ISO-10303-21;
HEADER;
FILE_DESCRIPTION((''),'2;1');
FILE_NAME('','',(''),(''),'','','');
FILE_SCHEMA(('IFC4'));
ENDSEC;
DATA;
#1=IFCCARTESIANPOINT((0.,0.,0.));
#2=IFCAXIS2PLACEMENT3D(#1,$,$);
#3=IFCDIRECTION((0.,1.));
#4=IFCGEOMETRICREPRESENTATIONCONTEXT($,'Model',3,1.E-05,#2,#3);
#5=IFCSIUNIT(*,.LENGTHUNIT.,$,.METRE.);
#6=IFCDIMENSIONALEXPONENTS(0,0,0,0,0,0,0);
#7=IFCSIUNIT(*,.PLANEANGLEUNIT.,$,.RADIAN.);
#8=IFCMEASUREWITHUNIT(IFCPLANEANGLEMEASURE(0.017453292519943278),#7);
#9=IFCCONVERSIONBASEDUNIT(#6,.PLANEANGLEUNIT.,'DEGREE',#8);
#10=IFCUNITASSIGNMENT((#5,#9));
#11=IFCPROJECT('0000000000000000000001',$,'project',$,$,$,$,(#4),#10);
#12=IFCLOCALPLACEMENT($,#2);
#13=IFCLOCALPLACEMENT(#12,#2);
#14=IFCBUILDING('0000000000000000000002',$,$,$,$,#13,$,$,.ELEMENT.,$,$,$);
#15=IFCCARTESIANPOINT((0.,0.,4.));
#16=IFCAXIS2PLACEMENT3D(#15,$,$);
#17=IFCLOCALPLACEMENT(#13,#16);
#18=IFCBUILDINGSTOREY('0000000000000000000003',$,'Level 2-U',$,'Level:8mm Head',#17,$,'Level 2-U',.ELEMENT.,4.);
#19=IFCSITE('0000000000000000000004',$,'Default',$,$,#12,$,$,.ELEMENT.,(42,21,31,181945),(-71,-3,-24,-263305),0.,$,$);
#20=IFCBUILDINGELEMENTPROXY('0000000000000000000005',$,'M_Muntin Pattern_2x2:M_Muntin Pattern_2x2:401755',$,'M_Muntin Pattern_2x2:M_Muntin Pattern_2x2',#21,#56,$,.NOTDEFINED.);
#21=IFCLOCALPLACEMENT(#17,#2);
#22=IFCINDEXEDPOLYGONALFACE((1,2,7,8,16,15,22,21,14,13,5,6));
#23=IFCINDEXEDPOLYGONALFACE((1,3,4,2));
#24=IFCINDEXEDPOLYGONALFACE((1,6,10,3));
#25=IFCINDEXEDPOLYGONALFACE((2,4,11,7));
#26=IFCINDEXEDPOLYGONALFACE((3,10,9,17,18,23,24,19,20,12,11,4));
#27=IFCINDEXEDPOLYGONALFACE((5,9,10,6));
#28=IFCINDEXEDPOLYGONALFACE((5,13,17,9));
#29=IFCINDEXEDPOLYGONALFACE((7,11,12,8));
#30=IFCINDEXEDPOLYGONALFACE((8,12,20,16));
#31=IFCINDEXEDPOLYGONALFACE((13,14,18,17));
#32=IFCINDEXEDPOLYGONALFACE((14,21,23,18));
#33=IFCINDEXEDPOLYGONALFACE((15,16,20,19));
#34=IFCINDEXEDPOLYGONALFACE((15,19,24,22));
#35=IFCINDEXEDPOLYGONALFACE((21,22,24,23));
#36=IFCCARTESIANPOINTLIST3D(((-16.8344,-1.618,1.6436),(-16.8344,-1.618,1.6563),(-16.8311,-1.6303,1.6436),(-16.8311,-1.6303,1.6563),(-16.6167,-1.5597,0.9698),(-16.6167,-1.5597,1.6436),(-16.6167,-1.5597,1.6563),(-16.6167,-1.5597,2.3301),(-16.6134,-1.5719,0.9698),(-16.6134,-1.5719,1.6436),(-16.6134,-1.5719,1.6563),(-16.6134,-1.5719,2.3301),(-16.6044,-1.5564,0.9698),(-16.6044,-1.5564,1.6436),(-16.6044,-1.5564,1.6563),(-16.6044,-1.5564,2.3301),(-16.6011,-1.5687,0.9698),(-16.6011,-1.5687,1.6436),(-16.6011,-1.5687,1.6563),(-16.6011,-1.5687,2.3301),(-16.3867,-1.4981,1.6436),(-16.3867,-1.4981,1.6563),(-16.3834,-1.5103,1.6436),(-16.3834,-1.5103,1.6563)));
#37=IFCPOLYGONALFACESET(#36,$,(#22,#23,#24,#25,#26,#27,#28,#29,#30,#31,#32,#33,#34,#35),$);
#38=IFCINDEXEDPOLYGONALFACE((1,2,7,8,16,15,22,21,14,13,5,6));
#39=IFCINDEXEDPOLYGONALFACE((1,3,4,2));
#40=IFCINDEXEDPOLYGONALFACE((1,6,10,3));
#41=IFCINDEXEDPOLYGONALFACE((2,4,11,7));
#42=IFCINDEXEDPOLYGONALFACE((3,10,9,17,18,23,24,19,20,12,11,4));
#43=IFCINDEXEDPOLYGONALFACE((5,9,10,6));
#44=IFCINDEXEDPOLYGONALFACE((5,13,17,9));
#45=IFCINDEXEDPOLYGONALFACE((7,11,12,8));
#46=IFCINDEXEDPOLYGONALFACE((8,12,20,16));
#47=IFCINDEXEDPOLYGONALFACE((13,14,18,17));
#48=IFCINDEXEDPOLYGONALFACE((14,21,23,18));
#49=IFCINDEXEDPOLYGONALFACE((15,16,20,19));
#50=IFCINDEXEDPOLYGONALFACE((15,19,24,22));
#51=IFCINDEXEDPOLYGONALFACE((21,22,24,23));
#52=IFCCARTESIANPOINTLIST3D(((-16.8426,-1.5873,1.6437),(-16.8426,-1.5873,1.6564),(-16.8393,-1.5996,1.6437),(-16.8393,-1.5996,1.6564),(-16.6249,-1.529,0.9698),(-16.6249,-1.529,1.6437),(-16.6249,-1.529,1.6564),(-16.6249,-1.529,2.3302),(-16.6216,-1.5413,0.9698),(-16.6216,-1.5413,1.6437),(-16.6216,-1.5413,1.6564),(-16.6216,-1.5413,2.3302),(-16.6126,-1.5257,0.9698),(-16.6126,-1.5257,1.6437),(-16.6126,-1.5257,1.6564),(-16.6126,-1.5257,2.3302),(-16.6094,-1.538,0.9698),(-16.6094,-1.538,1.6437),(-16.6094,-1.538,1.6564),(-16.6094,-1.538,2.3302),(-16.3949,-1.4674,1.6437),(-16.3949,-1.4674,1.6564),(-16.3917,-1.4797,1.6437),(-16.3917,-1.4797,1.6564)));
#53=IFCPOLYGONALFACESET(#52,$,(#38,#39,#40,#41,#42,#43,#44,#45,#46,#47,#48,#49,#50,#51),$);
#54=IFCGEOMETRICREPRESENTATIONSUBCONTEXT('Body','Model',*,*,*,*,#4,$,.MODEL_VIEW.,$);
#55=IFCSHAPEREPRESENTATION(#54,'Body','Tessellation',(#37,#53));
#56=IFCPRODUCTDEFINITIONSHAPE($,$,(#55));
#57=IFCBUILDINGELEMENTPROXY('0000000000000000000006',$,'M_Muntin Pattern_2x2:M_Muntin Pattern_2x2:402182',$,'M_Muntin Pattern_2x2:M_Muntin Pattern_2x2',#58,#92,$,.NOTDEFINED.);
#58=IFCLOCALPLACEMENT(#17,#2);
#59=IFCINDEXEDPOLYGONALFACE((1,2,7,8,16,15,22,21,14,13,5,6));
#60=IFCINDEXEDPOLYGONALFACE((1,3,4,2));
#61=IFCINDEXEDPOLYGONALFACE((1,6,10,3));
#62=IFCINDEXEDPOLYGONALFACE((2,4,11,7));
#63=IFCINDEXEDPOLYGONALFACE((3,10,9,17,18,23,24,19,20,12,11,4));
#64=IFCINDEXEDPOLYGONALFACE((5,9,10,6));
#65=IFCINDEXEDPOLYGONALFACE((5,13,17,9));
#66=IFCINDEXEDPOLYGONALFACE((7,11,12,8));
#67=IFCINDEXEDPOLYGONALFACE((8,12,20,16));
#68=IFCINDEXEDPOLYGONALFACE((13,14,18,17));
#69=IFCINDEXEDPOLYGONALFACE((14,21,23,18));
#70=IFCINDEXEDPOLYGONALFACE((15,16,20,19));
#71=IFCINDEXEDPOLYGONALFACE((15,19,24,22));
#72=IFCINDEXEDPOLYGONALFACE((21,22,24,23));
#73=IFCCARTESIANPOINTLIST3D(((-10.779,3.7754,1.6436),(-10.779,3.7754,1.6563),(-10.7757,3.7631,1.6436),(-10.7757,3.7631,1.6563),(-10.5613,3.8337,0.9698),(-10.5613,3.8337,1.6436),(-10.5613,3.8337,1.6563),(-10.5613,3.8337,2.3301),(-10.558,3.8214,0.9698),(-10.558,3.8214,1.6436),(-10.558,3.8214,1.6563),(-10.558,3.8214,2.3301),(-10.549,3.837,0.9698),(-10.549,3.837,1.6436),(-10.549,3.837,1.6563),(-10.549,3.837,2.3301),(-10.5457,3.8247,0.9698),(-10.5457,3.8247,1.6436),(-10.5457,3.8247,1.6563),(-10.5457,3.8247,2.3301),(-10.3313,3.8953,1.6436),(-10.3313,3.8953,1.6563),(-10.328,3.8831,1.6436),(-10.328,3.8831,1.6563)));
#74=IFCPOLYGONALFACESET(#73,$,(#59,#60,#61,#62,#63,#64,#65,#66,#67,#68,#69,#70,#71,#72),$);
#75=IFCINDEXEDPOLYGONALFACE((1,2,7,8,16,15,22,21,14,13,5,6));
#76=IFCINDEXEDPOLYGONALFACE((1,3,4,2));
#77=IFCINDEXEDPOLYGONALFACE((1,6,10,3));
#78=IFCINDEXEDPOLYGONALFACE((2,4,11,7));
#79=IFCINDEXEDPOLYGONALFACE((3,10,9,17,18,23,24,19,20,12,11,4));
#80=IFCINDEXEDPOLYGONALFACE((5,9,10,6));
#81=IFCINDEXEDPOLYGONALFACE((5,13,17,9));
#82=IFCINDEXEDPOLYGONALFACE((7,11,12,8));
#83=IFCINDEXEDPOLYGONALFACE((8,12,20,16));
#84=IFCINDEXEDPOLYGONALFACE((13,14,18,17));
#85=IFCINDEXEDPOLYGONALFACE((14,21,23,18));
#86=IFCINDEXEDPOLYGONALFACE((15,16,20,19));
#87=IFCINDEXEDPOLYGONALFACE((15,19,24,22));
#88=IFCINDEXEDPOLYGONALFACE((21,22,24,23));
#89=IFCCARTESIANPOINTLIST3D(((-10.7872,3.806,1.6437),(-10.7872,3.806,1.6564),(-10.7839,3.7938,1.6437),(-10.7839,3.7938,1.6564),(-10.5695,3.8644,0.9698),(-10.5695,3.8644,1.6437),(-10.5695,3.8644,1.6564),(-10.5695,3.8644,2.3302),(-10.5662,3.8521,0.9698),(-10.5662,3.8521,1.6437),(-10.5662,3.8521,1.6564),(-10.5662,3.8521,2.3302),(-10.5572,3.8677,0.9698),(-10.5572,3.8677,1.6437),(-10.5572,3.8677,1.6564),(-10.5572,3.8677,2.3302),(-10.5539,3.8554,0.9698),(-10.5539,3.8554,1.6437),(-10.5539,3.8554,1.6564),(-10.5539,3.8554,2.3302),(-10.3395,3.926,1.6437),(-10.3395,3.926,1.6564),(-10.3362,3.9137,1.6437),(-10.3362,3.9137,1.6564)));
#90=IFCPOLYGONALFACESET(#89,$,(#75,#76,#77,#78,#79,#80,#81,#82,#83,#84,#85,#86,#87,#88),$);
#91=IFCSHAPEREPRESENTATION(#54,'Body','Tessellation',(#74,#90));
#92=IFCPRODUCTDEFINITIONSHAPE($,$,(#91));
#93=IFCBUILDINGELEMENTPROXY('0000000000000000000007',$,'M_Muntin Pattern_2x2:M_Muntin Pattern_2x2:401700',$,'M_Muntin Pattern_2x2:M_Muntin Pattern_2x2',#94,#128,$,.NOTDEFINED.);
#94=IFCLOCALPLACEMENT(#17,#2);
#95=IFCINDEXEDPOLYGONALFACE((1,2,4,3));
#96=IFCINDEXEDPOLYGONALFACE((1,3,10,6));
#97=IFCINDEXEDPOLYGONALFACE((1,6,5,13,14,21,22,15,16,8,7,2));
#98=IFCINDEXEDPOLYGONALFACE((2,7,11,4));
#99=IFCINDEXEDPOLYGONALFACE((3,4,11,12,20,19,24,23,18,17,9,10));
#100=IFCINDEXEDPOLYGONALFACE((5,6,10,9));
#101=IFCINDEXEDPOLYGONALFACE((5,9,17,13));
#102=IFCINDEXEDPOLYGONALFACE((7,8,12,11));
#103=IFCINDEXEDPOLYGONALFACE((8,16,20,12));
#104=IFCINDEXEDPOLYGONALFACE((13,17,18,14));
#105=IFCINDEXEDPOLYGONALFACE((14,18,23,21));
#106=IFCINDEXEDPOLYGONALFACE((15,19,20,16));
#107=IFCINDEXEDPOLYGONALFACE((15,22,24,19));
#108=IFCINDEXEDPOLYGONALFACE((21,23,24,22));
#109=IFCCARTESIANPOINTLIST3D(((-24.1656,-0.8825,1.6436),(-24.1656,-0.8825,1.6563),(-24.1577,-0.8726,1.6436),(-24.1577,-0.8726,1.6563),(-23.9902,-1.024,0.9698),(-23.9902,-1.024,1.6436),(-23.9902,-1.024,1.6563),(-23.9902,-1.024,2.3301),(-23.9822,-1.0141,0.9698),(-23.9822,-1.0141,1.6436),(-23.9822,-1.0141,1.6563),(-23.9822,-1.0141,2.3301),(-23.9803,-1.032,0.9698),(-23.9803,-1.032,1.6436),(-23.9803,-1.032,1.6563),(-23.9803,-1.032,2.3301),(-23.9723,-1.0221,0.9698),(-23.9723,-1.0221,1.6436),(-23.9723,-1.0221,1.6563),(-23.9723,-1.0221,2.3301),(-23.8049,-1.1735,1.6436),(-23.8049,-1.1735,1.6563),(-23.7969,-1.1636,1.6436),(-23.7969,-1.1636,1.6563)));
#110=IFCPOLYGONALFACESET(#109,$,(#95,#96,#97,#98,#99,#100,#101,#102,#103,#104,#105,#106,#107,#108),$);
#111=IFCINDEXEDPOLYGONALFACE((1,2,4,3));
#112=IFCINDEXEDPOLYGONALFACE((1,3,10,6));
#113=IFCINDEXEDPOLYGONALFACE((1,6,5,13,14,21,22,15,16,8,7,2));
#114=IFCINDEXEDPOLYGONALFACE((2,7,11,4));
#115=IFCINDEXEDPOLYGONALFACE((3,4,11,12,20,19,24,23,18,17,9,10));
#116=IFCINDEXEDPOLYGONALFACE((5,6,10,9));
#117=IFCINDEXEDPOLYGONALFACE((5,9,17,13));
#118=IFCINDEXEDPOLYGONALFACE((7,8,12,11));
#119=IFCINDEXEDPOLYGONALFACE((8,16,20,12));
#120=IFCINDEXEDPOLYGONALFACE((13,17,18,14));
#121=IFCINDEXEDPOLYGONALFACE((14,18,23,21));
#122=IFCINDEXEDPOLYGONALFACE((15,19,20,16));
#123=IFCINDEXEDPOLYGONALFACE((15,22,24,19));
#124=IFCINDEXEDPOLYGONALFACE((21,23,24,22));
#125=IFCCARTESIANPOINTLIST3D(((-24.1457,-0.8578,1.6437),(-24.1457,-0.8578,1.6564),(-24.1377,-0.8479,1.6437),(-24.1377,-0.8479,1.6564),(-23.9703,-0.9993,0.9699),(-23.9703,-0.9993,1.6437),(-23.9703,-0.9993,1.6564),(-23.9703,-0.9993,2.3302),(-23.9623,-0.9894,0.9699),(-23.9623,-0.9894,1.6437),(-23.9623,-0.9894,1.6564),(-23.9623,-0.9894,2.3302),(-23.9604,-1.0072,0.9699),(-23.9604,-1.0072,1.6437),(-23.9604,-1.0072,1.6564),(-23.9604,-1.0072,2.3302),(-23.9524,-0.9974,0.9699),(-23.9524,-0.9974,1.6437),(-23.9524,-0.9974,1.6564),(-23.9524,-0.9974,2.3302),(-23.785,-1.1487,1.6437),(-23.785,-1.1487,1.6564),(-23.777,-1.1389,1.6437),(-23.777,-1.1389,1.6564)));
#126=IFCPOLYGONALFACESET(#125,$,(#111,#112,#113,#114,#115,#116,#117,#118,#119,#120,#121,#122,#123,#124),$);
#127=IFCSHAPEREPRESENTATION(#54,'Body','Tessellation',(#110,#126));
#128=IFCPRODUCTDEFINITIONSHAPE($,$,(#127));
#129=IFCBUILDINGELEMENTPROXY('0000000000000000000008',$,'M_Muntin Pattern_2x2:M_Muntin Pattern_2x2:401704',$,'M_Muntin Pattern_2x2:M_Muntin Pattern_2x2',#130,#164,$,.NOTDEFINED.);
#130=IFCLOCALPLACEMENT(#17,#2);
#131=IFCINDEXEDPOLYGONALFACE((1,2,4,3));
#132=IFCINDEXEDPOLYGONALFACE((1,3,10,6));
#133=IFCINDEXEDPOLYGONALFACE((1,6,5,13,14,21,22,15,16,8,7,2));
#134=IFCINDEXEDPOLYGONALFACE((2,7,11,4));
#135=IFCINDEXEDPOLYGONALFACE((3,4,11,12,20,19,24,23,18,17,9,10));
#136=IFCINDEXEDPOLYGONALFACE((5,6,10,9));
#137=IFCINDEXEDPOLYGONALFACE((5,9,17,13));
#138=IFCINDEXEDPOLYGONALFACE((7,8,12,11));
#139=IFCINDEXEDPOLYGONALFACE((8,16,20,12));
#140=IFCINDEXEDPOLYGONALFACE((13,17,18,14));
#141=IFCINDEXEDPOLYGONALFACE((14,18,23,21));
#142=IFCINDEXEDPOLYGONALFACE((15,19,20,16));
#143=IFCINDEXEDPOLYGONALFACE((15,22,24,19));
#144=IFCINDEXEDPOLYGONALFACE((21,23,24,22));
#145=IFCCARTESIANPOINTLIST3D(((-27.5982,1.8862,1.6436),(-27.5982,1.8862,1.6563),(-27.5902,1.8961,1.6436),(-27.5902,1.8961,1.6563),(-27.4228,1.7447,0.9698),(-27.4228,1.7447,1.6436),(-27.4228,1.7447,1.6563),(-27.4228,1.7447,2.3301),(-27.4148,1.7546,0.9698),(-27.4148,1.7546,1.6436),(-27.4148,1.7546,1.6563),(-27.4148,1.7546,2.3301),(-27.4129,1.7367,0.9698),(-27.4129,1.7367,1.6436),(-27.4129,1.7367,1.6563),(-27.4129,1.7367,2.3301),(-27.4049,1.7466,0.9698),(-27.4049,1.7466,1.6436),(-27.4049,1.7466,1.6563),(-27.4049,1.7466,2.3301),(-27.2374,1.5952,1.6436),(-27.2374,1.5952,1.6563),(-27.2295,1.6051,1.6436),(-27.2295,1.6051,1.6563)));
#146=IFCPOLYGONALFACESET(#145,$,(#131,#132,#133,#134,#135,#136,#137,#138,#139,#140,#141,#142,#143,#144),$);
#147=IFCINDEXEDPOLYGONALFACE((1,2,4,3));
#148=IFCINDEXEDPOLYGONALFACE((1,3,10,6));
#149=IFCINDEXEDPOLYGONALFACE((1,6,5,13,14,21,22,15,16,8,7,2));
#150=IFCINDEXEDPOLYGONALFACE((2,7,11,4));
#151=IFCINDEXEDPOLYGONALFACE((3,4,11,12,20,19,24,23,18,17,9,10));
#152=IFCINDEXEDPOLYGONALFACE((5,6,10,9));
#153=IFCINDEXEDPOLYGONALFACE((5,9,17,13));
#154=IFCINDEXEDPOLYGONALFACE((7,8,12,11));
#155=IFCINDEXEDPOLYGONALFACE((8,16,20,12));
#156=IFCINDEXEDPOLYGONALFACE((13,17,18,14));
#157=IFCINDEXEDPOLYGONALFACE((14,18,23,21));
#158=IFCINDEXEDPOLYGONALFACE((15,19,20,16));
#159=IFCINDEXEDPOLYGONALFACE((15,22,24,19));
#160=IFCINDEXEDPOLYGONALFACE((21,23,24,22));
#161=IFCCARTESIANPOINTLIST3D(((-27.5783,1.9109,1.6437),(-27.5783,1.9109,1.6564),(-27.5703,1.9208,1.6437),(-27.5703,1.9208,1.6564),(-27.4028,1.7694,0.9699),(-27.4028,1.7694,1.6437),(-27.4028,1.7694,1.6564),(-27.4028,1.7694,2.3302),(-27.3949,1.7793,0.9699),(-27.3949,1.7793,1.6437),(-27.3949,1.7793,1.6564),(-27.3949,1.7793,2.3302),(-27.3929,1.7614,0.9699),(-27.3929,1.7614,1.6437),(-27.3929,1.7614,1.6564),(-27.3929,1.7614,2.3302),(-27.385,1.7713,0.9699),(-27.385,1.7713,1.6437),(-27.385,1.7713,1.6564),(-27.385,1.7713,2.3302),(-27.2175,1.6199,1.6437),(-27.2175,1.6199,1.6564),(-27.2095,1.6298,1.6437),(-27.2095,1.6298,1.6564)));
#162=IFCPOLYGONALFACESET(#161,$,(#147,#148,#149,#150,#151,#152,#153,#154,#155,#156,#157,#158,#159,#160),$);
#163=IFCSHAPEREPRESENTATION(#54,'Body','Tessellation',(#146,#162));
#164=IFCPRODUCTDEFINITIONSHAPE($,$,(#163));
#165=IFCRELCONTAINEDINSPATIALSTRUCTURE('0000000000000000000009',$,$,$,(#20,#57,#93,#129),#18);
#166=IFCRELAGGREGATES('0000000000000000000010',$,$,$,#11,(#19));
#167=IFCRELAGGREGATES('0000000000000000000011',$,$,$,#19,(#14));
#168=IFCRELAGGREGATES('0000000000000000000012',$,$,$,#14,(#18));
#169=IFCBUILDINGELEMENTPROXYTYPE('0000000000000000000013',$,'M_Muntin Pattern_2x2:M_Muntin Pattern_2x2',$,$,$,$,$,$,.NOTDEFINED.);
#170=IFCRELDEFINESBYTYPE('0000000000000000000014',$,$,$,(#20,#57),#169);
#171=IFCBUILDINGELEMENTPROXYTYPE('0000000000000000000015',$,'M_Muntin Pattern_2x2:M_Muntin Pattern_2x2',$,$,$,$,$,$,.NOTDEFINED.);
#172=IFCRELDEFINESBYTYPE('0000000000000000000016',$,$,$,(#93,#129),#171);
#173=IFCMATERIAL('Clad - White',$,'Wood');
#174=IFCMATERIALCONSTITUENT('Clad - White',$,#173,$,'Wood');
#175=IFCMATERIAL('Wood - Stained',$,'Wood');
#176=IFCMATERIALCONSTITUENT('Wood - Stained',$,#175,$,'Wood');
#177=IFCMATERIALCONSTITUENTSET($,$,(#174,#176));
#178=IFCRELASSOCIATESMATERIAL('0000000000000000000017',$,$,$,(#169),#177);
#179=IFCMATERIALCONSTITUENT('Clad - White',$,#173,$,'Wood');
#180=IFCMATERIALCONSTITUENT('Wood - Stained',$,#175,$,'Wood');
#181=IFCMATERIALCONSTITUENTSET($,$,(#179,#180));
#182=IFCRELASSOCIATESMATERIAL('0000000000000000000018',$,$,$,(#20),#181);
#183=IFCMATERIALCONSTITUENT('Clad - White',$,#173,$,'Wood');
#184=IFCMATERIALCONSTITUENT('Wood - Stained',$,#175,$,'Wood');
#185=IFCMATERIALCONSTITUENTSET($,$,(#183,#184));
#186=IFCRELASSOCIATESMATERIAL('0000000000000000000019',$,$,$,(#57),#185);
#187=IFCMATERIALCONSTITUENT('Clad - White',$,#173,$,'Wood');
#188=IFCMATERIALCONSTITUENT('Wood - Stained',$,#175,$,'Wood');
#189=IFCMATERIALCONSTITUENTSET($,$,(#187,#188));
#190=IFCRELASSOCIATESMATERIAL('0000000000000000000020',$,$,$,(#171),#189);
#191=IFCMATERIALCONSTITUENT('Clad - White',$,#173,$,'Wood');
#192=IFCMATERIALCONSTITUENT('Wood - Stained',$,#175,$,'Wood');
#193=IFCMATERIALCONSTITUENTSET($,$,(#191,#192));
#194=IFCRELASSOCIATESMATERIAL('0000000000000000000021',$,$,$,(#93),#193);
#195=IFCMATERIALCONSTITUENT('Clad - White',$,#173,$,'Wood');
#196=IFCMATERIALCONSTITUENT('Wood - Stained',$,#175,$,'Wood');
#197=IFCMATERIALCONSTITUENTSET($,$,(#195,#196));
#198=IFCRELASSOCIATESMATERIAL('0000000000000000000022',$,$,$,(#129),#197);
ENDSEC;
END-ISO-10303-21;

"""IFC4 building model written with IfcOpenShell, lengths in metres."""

from ifc_helpers import new_model, entity, si_unit, converted_unit, direction, frame, origin, place, context, subcontext, project, spatial, polyline, outline, extrude, source, transform, mapped, material, constituent, constituent_set, type_object, type_shapes, element, save


model = new_model("IFC4")

# Units and contexts
model_context = context("Model", 3, precision=1e-05, world=origin(), true_north=direction((0.0, 1.0)))
body_context = subcontext(model_context, "Body", "Model", "MODEL_VIEW")
ifc_project = project(units=[si_unit("LENGTHUNIT", "METRE"), converted_unit("PLANEANGLEUNIT", "DEGREE", entity("IfcPlaneAngleMeasure", 0.017453292519943278), si_unit("PLANEANGLEUNIT", "RADIAN"), dimensions=[0, 0, 0, 0, 0, 0, 0])], contexts=[model_context])

# Site, building, storey
site_placement = place(None, origin())
site = spatial("IfcSite", under=ifc_project, at=site_placement, Name="Default", CompositionType="ELEMENT", RefLatitude=(42, 21, 31, 181945), RefLongitude=(-71, -3, -24, -263305), RefElevation=0.0)
building_placement = place(site_placement, origin())
building = spatial("IfcBuilding", under=site, at=building_placement, CompositionType="ELEMENT")
storey_placement = place(building_placement, frame((0.0, 0.0, 4.0)))
storey = spatial("IfcBuildingStorey", under=building, at=storey_placement, Name="Level 2-U", ObjectType="Level:8mm Head", LongName="Level 2-U", CompositionType="ELEMENT", Elevation=4.0)

# Building element proxies
ifc_material_1 = material(Name="Clad - White", Category="Wood")
ifc_material_2 = material(Name="Wood - Stained", Category="Wood")
ifc_constituent_1 = constituent(ifc_material_1, Name="Clad - White", Category="Wood")
ifc_constituent_2 = constituent(ifc_material_2, Name="Wood - Stained", Category="Wood")
ifc_constituent_set_1 = constituent_set(constituents=[ifc_constituent_1, ifc_constituent_2])
building_element_proxy_type_1 = type_object("IfcBuildingElementProxyType", Name="M_Muntin Pattern_2x2:M_Muntin Pattern_2x2", PredefinedType="NOTDEFINED", material=ifc_constituent_set_1)
shared_shape_1 = source(origin(), body_context, "Body", "SweptSolid", [
    extrude(outline(polyline([(0.0064, -0.0064), (0.6801, -0.0064), (0.6801, 0.0063), (0.0064, 0.0063), (0.0064, 0.2317), (-0.0063, 0.2317), (-0.0063, 0.0063), (-0.6802, 0.0063), (-0.6802, -0.0064), (-0.0063, -0.0064), (-0.0063, -0.2317), (0.0064, -0.2317), (0.0064, -0.0064)])), frame((0.0, 0.0095, 0.6801), z_axis=(0.0, 1.0, 0.0), x_axis=(0.0, 0.0, 1.0)), (0.0, 0.0, 1.0), 0.0127),
    extrude(outline(polyline([(0.0064, -0.0064), (0.6802, -0.0064), (0.6802, 0.0063), (0.0064, 0.0063), (0.0064, 0.2317), (-0.0063, 0.2317), (-0.0063, 0.0063), (-0.6802, 0.0063), (-0.6802, -0.0064), (-0.0063, -0.0064), (-0.0063, -0.2317), (0.0064, -0.2317), (0.0064, -0.0064)])), frame((0.0, -0.0222, 0.6802), z_axis=(0.0, 1.0, 0.0), x_axis=(0.0, 0.0, 1.0)), (0.0, 0.0, 1.0), 0.0127),
])
type_shapes(building_element_proxy_type_1, [shared_shape_1])
ifc_constituent_3 = constituent(ifc_material_1, Name="Clad - White", Category="Wood")
ifc_constituent_4 = constituent(ifc_material_2, Name="Wood - Stained", Category="Wood")
ifc_constituent_set_2 = constituent_set(constituents=[ifc_constituent_3, ifc_constituent_4])
proxy_1_placement = place(storey_placement, frame((-16.613, -1.5488, 0.9698), z_axis=(0.0, 0.0, 1.0), x_axis=(-0.965926, -0.258819, 0.0)))
element("IfcBuildingElementProxy", 1, at=proxy_1_placement, inside=storey, type_object=building_element_proxy_type_1, material=ifc_constituent_set_2, Name="M_Muntin Pattern_2x2:M_Muntin Pattern_2x2:401755", ObjectType="M_Muntin Pattern_2x2:M_Muntin Pattern_2x2", PredefinedType="NOTDEFINED", context=body_context, shape_type="MappedRepresentation", body=[
    mapped(shared_shape_1, transform((0.0, 0.0, 0.0), scale=1.0)),
])
ifc_constituent_5 = constituent(ifc_material_1, Name="Clad - White", Category="Wood")
ifc_constituent_6 = constituent(ifc_material_2, Name="Wood - Stained", Category="Wood")
ifc_constituent_set_3 = constituent_set(constituents=[ifc_constituent_5, ifc_constituent_6])
proxy_2_placement = place(storey_placement, frame((-10.5576, 3.8446, 0.9698), z_axis=(0.0, 0.0, 1.0), x_axis=(-0.965926, -0.258819, 0.0)))
element("IfcBuildingElementProxy", 2, at=proxy_2_placement, inside=storey, type_object=building_element_proxy_type_1, material=ifc_constituent_set_3, Name="M_Muntin Pattern_2x2:M_Muntin Pattern_2x2:402182", ObjectType="M_Muntin Pattern_2x2:M_Muntin Pattern_2x2", PredefinedType="NOTDEFINED", context=body_context, shape_type="MappedRepresentation", body=[
    mapped(shared_shape_1, transform((0.0, 0.0, 0.0), scale=1.0)),
])
ifc_constituent_7 = constituent(ifc_material_1, Name="Clad - White", Category="Wood")
ifc_constituent_8 = constituent(ifc_material_2, Name="Wood - Stained", Category="Wood")
ifc_constituent_set_4 = constituent_set(constituents=[ifc_constituent_7, ifc_constituent_8])
ifc_constituent_9 = constituent(ifc_material_1, Name="Clad - White", Category="Wood")
ifc_constituent_10 = constituent(ifc_material_2, Name="Wood - Stained", Category="Wood")
ifc_constituent_set_5 = constituent_set(constituents=[ifc_constituent_9, ifc_constituent_10])
building_element_proxy_type_2 = type_object("IfcBuildingElementProxyType", Name="M_Muntin Pattern_2x2:M_Muntin Pattern_2x2", PredefinedType="NOTDEFINED", material=ifc_constituent_set_5)
shared_shape_2 = source(origin(), body_context, "Body", "SweptSolid", [
    extrude(outline(polyline([(0.0064, -0.0064), (0.6801, -0.0064), (0.6801, 0.0063), (0.0064, 0.0063), (0.0064, 0.2317), (-0.0063, 0.2317), (-0.0063, 0.0063), (-0.6802, 0.0063), (-0.6802, -0.0064), (-0.0063, -0.0064), (-0.0063, -0.2317), (0.0064, -0.2317), (0.0064, -0.0064)])), frame((0.0, -0.0222, 0.6801), z_axis=(0.0, 1.0, 0.0), x_axis=(0.0, 0.0, 1.0)), (0.0, 0.0, 1.0), 0.0127),
    extrude(outline(polyline([(0.0064, -0.0064), (0.6802, -0.0064), (0.6802, 0.0063), (0.0064, 0.0063), (0.0064, 0.2317), (-0.0063, 0.2317), (-0.0063, 0.0063), (-0.6802, 0.0063), (-0.6802, -0.0064), (-0.0063, -0.0064), (-0.0063, -0.2317), (0.0064, -0.2317), (0.0064, -0.0064)])), frame((0.0, 0.0095, 0.6802), z_axis=(0.0, 1.0, 0.0), x_axis=(0.0, 0.0, 1.0)), (0.0, 0.0, 1.0), 0.0127),
])
type_shapes(building_element_proxy_type_2, [shared_shape_2])
proxy_3_placement = place(storey_placement, frame((-23.9713, -1.0107, 0.9699), z_axis=(0.0, 0.0, 1.0), x_axis=(0.778359, -0.62782, 0.0)))
element("IfcBuildingElementProxy", 3, at=proxy_3_placement, inside=storey, type_object=building_element_proxy_type_2, material=ifc_constituent_set_4, Name="M_Muntin Pattern_2x2:M_Muntin Pattern_2x2:401700", ObjectType="M_Muntin Pattern_2x2:M_Muntin Pattern_2x2", PredefinedType="NOTDEFINED", context=body_context, shape_type="MappedRepresentation", body=[
    mapped(shared_shape_2, transform((0.0, 0.0, 0.0), scale=1.0)),
])
ifc_constituent_11 = constituent(ifc_material_1, Name="Clad - White", Category="Wood")
ifc_constituent_12 = constituent(ifc_material_2, Name="Wood - Stained", Category="Wood")
ifc_constituent_set_6 = constituent_set(constituents=[ifc_constituent_11, ifc_constituent_12])
proxy_4_placement = place(storey_placement, frame((-27.4039, 1.758, 0.9699), z_axis=(0.0, 0.0, 1.0), x_axis=(0.778359, -0.62782, 0.0)))
element("IfcBuildingElementProxy", 4, at=proxy_4_placement, inside=storey, type_object=building_element_proxy_type_2, material=ifc_constituent_set_6, Name="M_Muntin Pattern_2x2:M_Muntin Pattern_2x2:401704", ObjectType="M_Muntin Pattern_2x2:M_Muntin Pattern_2x2", PredefinedType="NOTDEFINED", context=body_context, shape_type="MappedRepresentation", body=[
    mapped(shared_shape_2, transform((0.0, 0.0, 0.0), scale=1.0)),
])

save(model, "model.ifc")
